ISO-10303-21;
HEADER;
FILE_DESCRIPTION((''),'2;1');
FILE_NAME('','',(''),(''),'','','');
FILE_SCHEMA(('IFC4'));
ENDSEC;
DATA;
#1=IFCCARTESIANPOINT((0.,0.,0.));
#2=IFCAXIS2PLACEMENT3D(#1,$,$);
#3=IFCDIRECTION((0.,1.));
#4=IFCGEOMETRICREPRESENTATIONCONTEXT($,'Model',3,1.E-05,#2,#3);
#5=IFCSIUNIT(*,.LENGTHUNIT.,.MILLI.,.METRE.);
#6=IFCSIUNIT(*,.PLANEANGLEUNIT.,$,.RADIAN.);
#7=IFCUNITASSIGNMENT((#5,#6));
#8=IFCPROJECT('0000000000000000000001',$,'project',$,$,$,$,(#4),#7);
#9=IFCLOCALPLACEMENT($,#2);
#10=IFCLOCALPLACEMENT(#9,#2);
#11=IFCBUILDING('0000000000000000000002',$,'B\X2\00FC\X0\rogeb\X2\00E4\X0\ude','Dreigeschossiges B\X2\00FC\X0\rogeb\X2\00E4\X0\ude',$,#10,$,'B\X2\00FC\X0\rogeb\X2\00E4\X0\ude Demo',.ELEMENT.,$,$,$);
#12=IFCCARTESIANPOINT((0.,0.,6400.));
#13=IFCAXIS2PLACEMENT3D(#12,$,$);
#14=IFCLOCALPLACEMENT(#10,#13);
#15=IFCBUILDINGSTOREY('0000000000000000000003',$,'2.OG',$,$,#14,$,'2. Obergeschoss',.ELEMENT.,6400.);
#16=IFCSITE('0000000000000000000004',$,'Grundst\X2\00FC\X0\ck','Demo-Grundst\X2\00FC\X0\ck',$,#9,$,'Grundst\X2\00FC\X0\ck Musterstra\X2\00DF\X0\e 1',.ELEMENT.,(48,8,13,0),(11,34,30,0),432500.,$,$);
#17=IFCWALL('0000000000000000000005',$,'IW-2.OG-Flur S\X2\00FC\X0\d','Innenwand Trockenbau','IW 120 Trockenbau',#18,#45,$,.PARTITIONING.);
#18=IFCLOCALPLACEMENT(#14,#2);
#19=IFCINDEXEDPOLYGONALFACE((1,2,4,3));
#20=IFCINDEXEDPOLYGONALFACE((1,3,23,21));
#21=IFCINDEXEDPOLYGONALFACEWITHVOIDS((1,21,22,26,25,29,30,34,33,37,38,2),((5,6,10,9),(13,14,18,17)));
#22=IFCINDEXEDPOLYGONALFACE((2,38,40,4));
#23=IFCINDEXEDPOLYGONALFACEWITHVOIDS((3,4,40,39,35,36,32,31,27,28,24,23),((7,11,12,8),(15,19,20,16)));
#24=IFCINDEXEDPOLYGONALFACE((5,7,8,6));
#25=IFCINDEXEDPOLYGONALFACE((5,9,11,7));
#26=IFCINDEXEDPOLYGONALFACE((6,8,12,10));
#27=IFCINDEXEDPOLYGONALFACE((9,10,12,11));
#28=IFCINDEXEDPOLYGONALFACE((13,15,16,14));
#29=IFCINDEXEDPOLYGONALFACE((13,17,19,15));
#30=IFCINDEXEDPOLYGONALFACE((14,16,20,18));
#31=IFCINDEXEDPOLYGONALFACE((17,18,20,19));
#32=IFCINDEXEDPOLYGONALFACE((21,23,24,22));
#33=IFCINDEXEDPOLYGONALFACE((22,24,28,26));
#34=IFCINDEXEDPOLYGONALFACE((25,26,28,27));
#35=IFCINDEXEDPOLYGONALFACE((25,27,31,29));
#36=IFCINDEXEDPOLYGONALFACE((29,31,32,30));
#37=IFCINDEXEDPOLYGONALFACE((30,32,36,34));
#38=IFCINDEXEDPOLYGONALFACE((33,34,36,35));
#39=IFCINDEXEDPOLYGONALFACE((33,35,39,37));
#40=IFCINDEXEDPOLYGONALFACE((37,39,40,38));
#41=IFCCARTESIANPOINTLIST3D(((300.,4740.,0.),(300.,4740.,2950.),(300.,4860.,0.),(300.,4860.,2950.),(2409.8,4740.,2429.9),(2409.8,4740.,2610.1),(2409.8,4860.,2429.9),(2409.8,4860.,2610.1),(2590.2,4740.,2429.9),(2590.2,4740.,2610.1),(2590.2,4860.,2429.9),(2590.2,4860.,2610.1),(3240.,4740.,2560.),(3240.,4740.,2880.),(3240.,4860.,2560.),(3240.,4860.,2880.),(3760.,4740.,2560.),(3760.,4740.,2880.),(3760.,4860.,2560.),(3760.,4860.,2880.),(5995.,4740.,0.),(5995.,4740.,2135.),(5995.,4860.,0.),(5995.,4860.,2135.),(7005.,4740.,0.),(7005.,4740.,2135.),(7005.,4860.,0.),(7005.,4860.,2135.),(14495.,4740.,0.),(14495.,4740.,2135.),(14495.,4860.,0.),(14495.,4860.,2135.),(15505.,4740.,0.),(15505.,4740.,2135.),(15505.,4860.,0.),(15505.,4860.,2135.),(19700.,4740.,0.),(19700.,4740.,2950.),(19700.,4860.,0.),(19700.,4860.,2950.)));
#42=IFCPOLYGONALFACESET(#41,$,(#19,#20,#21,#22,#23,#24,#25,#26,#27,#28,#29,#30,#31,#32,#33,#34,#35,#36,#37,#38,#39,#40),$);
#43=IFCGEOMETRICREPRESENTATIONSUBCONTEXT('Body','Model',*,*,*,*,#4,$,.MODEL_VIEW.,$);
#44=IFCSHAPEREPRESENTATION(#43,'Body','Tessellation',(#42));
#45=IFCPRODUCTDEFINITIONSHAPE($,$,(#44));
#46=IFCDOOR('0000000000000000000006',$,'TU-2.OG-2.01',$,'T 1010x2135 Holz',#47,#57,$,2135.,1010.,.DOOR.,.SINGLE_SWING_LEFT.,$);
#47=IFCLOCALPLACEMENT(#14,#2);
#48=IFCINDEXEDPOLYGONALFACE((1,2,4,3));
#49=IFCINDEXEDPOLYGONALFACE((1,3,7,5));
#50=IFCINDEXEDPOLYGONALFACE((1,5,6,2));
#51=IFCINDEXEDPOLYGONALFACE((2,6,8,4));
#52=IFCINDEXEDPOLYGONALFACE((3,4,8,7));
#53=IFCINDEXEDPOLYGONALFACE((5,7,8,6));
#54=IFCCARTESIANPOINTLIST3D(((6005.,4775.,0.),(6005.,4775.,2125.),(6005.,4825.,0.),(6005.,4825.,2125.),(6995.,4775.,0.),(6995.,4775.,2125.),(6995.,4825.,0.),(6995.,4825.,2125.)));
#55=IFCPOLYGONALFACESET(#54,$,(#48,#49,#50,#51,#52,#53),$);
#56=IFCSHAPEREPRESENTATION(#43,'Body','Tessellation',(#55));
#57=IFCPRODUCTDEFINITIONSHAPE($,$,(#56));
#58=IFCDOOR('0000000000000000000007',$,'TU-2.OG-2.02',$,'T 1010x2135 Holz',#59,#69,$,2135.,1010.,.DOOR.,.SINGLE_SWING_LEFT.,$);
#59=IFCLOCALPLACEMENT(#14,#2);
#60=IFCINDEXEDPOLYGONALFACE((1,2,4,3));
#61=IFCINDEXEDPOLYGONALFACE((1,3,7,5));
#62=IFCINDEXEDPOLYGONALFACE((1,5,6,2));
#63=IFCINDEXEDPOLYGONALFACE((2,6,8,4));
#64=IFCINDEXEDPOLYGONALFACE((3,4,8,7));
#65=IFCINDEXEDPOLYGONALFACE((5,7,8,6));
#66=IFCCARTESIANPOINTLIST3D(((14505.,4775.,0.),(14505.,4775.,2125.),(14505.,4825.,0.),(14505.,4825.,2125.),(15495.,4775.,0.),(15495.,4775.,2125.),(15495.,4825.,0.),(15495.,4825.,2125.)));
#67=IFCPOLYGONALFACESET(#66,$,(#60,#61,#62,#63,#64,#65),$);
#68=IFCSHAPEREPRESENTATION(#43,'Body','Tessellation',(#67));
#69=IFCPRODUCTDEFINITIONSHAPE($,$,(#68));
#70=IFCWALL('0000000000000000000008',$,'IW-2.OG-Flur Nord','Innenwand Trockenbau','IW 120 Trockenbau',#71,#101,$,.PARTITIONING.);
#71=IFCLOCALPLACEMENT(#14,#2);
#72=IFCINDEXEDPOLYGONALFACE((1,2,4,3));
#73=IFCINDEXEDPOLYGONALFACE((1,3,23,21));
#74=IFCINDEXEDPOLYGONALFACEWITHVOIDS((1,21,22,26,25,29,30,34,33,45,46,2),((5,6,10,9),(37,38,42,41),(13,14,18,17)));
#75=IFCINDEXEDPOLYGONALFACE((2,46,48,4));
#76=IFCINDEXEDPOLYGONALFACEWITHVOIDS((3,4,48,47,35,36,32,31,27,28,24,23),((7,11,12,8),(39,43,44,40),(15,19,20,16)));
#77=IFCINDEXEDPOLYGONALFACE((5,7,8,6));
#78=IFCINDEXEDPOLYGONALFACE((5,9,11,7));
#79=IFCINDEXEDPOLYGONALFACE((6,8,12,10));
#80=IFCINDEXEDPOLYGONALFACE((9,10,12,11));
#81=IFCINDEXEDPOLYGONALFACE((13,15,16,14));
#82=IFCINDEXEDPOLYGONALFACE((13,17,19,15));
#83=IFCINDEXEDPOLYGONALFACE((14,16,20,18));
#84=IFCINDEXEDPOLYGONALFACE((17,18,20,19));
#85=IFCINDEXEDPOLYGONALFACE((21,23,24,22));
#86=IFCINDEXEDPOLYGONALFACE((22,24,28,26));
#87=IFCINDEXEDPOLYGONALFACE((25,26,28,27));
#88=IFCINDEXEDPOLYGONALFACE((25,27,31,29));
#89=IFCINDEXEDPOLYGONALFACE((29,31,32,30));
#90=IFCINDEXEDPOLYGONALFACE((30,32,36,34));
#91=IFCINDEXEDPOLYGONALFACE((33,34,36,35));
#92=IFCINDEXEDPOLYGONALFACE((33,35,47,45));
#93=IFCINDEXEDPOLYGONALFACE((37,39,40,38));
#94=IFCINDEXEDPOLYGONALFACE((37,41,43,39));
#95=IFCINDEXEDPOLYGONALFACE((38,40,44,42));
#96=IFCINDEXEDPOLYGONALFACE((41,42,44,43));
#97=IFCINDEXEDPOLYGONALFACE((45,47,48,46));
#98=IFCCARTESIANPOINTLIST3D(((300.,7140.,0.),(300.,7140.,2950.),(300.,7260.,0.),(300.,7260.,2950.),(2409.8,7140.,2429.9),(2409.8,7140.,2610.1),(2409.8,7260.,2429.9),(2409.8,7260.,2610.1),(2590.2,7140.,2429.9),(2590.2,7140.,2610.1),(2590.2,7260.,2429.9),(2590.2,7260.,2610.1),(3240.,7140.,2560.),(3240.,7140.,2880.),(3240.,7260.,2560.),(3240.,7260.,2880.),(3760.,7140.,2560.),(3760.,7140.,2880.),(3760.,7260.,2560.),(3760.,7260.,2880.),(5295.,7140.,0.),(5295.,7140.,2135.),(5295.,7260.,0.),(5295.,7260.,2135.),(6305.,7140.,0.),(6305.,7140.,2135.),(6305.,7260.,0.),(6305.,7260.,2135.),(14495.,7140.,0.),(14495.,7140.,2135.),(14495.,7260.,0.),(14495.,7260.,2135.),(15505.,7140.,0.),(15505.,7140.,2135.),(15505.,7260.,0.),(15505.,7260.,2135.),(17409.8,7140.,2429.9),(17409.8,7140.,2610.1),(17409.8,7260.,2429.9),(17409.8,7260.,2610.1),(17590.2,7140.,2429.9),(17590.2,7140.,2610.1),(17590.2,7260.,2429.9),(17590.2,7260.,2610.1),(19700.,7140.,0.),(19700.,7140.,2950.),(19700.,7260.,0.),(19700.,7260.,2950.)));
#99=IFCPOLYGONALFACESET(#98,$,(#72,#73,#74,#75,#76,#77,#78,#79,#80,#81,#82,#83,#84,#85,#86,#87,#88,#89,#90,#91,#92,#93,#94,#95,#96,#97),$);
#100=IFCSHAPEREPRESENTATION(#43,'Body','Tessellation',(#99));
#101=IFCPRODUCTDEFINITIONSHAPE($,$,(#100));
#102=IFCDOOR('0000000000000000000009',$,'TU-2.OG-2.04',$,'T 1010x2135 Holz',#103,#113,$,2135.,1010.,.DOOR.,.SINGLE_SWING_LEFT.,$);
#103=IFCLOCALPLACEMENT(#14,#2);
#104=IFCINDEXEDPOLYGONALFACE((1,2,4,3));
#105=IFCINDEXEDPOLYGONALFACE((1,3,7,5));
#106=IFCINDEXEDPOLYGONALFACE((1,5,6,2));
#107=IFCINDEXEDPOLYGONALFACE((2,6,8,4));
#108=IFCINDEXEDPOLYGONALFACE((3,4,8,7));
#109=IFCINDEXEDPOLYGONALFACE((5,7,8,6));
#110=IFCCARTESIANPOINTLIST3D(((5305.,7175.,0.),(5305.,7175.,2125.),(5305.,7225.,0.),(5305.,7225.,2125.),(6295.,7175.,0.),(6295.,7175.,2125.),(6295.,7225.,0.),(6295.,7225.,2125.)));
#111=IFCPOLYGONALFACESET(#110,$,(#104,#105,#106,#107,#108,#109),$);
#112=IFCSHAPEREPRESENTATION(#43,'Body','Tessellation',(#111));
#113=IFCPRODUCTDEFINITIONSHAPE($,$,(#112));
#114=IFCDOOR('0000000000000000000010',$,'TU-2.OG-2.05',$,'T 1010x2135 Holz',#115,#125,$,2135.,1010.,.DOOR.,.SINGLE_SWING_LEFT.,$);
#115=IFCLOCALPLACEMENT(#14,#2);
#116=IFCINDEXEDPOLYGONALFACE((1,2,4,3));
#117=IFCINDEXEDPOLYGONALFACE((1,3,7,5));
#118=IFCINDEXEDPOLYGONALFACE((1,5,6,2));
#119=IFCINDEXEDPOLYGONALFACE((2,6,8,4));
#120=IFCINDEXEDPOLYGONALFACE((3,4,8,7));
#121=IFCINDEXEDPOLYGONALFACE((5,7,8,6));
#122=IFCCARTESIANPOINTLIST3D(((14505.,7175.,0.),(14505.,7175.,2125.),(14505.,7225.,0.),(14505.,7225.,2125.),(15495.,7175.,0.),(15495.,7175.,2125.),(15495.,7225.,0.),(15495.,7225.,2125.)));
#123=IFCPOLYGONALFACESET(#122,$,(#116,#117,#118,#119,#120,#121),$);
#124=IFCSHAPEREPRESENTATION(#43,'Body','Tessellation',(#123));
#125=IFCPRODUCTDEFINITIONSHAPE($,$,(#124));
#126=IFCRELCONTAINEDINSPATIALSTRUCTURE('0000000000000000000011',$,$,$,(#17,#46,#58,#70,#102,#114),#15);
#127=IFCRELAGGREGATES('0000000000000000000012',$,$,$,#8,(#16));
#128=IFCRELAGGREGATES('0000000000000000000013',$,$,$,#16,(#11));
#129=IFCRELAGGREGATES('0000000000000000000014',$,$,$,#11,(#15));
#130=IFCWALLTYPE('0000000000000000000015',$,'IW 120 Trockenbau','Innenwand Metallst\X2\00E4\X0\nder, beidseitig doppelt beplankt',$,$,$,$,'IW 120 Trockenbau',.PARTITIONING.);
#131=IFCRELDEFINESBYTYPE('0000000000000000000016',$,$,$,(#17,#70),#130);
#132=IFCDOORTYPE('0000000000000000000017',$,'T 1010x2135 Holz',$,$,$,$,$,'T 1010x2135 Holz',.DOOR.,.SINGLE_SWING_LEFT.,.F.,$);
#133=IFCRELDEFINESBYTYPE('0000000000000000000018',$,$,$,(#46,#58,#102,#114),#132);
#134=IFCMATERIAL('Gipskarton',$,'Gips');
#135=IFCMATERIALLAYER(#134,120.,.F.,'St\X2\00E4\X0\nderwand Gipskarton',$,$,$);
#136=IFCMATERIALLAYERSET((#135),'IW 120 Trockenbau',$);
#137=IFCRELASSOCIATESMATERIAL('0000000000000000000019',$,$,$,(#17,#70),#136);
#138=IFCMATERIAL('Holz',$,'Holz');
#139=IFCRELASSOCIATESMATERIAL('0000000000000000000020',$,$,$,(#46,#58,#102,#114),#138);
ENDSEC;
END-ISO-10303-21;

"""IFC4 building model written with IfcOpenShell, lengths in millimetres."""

from ifc_helpers import new_model, si_unit, direction, frame, frame_2d, origin, origin_2d, place, context, subcontext, project, spatial, rectangle, extrude, material, layer, layer_set, layer_usage, type_object, element, fill, save


model = new_model("IFC4")

# Units and contexts
model_context = context("Model", 3, precision=1e-05, world=origin(), true_north=direction((0.0, 1.0)))
body_context = subcontext(model_context, "Body", "Model", "MODEL_VIEW")
ifc_project = project(units=[si_unit("LENGTHUNIT", "METRE", prefix="MILLI"), si_unit("PLANEANGLEUNIT", "RADIAN")], contexts=[model_context])

# Site, building, storey
site_placement = place(None, origin())
site = spatial("IfcSite", under=ifc_project, at=site_placement, Name="Grundstück", Description="Demo-Grundstück", LongName="Grundstück Musterstraße 1", CompositionType="ELEMENT", RefLatitude=(48, 8, 13, 0), RefLongitude=(11, 34, 30, 0), RefElevation=432500.0)
building_placement = place(site_placement, origin())
building = spatial("IfcBuilding", under=site, at=building_placement, Name="Bürogebäude", Description="Dreigeschossiges Bürogebäude", LongName="Bürogebäude Demo", CompositionType="ELEMENT")
storey_placement = place(building_placement, frame((0.0, 0.0, 6400.0)))
storey = spatial("IfcBuildingStorey", under=building, at=storey_placement, Name="2.OG", LongName="2. Obergeschoss", CompositionType="ELEMENT", Elevation=6400.0)

# Walls, openings, doors
ifc_material_1 = material(Name="Gipskarton", Category="Gips")
ifc_layer_1 = layer(ifc_material_1, 120.0, ventilated=False, Name="Ständerwand Gipskarton")
ifc_layer_set_1 = layer_set([ifc_layer_1], Name="IW 120 Trockenbau")
ifc_layer_usage_1 = layer_usage(ifc_layer_set_1, "AXIS2", "POSITIVE", -60.0)
wall_type_1 = type_object("IfcWallType", Name="IW 120 Trockenbau", Description="Innenwand Metallständer, beidseitig doppelt beplankt", ElementType="IW 120 Trockenbau", PredefinedType="PARTITIONING")
wall_1_placement = place(storey_placement, frame((300.0, 4800.0, 0.0)))
wall_1 = element("IfcWall", 1, at=wall_1_placement, inside=storey, type_object=wall_type_1, material=ifc_layer_usage_1, Name="IW-2.OG-Flur Süd", Description="Innenwand Trockenbau", ObjectType="IW 120 Trockenbau", PredefinedType="PARTITIONING", context=body_context, shape_type="SweptSolid", body=[
    extrude(rectangle(XDim=19400.0, YDim=120.0, at=frame_2d((9700.0, 0.0))), origin(), (0.0, 0.0, 1.0), 2950.0),
])
opening_1_placement = place(wall_1_placement, frame((6200.0, 0.0, 0.0)))
opening_1 = element("IfcOpeningElement", 2, at=opening_1_placement, cuts=wall_1, PredefinedType="OPENING", context=body_context, shape_type="SweptSolid", body=[
    extrude(rectangle(XDim=1010.0, YDim=160.0, at=origin_2d()), frame((0.0, 0.0, -20.0)), (0.0, 0.0, 1.0), 2155.0),
])
opening_2_placement = place(wall_1_placement, frame((14700.0, 0.0, 0.0)))
opening_2 = element("IfcOpeningElement", 3, at=opening_2_placement, cuts=wall_1, PredefinedType="OPENING", context=body_context, shape_type="SweptSolid", body=[
    extrude(rectangle(XDim=1010.0, YDim=160.0, at=origin_2d()), frame((0.0, 0.0, -20.0)), (0.0, 0.0, 1.0), 2155.0),
])
opening_3_placement = place(wall_1_placement, frame((3200.0, 0.0, 2560.0)))
element("IfcOpeningElement", 4, at=opening_3_placement, cuts=wall_1, PredefinedType="OPENING", context=body_context, shape_type="SweptSolid", body=[
    extrude(rectangle(XDim=520.0, YDim=160.0, at=origin_2d()), origin(), (0.0, 0.0, 1.0), 320.0),
])
opening_4_placement = place(wall_1_placement, frame((2200.0, 0.0, 2429.8)))
element("IfcOpeningElement", 5, at=opening_4_placement, cuts=wall_1, PredefinedType="OPENING", context=body_context, shape_type="SweptSolid", body=[
    extrude(rectangle(XDim=180.3, YDim=160.0, at=origin_2d()), origin(), (0.0, 0.0, 1.0), 180.3),
])
ifc_material_2 = material(Name="Holz", Category="Holz")
door_type = type_object("IfcDoorType", Name="T 1010x2135 Holz", ElementType="T 1010x2135 Holz", OperationType="SINGLE_SWING_LEFT", ParameterTakesPrecedence=False, PredefinedType="DOOR")
door_1_placement = place(opening_1_placement, origin())
door_1 = element("IfcDoor", 6, at=door_1_placement, inside=storey, type_object=door_type, material=ifc_material_2, Name="TU-2.OG-2.01", ObjectType="T 1010x2135 Holz", OperationType="SINGLE_SWING_LEFT", OverallHeight=2135.0, OverallWidth=1010.0, PredefinedType="DOOR", context=body_context, shape_type="SweptSolid", body=[
    extrude(rectangle(XDim=990.0, YDim=50.0, at=origin_2d()), origin(), (0.0, 0.0, 1.0), 2125.0),
])
fill(opening_1, door_1)
door_2_placement = place(opening_2_placement, origin())
door_2 = element("IfcDoor", 7, at=door_2_placement, inside=storey, type_object=door_type, material=ifc_material_2, Name="TU-2.OG-2.02", ObjectType="T 1010x2135 Holz", OperationType="SINGLE_SWING_LEFT", OverallHeight=2135.0, OverallWidth=1010.0, PredefinedType="DOOR", context=body_context, shape_type="SweptSolid", body=[
    extrude(rectangle(XDim=990.0, YDim=50.0, at=origin_2d()), origin(), (0.0, 0.0, 1.0), 2125.0),
])
fill(opening_2, door_2)
wall_2_placement = place(storey_placement, frame((300.0, 7200.0, 0.0)))
wall_2 = element("IfcWall", 8, at=wall_2_placement, inside=storey, type_object=wall_type_1, material=ifc_layer_usage_1, Name="IW-2.OG-Flur Nord", Description="Innenwand Trockenbau", ObjectType="IW 120 Trockenbau", PredefinedType="PARTITIONING", context=body_context, shape_type="SweptSolid", body=[
    extrude(rectangle(XDim=19400.0, YDim=120.0, at=frame_2d((9700.0, 0.0))), origin(), (0.0, 0.0, 1.0), 2950.0),
])
opening_5_placement = place(wall_2_placement, frame((5500.0, 0.0, 0.0)))
opening_5 = element("IfcOpeningElement", 9, at=opening_5_placement, cuts=wall_2, PredefinedType="OPENING", context=body_context, shape_type="SweptSolid", body=[
    extrude(rectangle(XDim=1010.0, YDim=160.0, at=origin_2d()), frame((0.0, 0.0, -20.0)), (0.0, 0.0, 1.0), 2155.0),
])
opening_6_placement = place(wall_2_placement, frame((14700.0, 0.0, 0.0)))
opening_6 = element("IfcOpeningElement", 10, at=opening_6_placement, cuts=wall_2, PredefinedType="OPENING", context=body_context, shape_type="SweptSolid", body=[
    extrude(rectangle(XDim=1010.0, YDim=160.0, at=origin_2d()), frame((0.0, 0.0, -20.0)), (0.0, 0.0, 1.0), 2155.0),
])
opening_7_placement = place(wall_2_placement, frame((3200.0, 0.0, 2560.0)))
element("IfcOpeningElement", 11, at=opening_7_placement, cuts=wall_2, PredefinedType="OPENING", context=body_context, shape_type="SweptSolid", body=[
    extrude(rectangle(XDim=520.0, YDim=160.0, at=origin_2d()), origin(), (0.0, 0.0, 1.0), 320.0),
])
opening_8_placement = place(wall_2_placement, frame((2200.0, 0.0, 2429.8)))
element("IfcOpeningElement", 12, at=opening_8_placement, cuts=wall_2, PredefinedType="OPENING", context=body_context, shape_type="SweptSolid", body=[
    extrude(rectangle(XDim=180.3, YDim=160.0, at=origin_2d()), origin(), (0.0, 0.0, 1.0), 180.3),
])
opening_9_placement = place(wall_2_placement, frame((17200.0, 0.0, 2429.8)))
element("IfcOpeningElement", 13, at=opening_9_placement, cuts=wall_2, PredefinedType="OPENING", context=body_context, shape_type="SweptSolid", body=[
    extrude(rectangle(XDim=180.3, YDim=160.0, at=origin_2d()), origin(), (0.0, 0.0, 1.0), 180.3),
])
door_3_placement = place(opening_5_placement, origin())
door_3 = element("IfcDoor", 14, at=door_3_placement, inside=storey, type_object=door_type, material=ifc_material_2, Name="TU-2.OG-2.04", ObjectType="T 1010x2135 Holz", OperationType="SINGLE_SWING_LEFT", OverallHeight=2135.0, OverallWidth=1010.0, PredefinedType="DOOR", context=body_context, shape_type="SweptSolid", body=[
    extrude(rectangle(XDim=990.0, YDim=50.0, at=origin_2d()), origin(), (0.0, 0.0, 1.0), 2125.0),
])
fill(opening_5, door_3)
door_4_placement = place(opening_6_placement, origin())
door_4 = element("IfcDoor", 15, at=door_4_placement, inside=storey, type_object=door_type, material=ifc_material_2, Name="TU-2.OG-2.05", ObjectType="T 1010x2135 Holz", OperationType="SINGLE_SWING_LEFT", OverallHeight=2135.0, OverallWidth=1010.0, PredefinedType="DOOR", context=body_context, shape_type="SweptSolid", body=[
    extrude(rectangle(XDim=990.0, YDim=50.0, at=origin_2d()), origin(), (0.0, 0.0, 1.0), 2125.0),
])
fill(opening_6, door_4)

save(model, "model.ifc")
